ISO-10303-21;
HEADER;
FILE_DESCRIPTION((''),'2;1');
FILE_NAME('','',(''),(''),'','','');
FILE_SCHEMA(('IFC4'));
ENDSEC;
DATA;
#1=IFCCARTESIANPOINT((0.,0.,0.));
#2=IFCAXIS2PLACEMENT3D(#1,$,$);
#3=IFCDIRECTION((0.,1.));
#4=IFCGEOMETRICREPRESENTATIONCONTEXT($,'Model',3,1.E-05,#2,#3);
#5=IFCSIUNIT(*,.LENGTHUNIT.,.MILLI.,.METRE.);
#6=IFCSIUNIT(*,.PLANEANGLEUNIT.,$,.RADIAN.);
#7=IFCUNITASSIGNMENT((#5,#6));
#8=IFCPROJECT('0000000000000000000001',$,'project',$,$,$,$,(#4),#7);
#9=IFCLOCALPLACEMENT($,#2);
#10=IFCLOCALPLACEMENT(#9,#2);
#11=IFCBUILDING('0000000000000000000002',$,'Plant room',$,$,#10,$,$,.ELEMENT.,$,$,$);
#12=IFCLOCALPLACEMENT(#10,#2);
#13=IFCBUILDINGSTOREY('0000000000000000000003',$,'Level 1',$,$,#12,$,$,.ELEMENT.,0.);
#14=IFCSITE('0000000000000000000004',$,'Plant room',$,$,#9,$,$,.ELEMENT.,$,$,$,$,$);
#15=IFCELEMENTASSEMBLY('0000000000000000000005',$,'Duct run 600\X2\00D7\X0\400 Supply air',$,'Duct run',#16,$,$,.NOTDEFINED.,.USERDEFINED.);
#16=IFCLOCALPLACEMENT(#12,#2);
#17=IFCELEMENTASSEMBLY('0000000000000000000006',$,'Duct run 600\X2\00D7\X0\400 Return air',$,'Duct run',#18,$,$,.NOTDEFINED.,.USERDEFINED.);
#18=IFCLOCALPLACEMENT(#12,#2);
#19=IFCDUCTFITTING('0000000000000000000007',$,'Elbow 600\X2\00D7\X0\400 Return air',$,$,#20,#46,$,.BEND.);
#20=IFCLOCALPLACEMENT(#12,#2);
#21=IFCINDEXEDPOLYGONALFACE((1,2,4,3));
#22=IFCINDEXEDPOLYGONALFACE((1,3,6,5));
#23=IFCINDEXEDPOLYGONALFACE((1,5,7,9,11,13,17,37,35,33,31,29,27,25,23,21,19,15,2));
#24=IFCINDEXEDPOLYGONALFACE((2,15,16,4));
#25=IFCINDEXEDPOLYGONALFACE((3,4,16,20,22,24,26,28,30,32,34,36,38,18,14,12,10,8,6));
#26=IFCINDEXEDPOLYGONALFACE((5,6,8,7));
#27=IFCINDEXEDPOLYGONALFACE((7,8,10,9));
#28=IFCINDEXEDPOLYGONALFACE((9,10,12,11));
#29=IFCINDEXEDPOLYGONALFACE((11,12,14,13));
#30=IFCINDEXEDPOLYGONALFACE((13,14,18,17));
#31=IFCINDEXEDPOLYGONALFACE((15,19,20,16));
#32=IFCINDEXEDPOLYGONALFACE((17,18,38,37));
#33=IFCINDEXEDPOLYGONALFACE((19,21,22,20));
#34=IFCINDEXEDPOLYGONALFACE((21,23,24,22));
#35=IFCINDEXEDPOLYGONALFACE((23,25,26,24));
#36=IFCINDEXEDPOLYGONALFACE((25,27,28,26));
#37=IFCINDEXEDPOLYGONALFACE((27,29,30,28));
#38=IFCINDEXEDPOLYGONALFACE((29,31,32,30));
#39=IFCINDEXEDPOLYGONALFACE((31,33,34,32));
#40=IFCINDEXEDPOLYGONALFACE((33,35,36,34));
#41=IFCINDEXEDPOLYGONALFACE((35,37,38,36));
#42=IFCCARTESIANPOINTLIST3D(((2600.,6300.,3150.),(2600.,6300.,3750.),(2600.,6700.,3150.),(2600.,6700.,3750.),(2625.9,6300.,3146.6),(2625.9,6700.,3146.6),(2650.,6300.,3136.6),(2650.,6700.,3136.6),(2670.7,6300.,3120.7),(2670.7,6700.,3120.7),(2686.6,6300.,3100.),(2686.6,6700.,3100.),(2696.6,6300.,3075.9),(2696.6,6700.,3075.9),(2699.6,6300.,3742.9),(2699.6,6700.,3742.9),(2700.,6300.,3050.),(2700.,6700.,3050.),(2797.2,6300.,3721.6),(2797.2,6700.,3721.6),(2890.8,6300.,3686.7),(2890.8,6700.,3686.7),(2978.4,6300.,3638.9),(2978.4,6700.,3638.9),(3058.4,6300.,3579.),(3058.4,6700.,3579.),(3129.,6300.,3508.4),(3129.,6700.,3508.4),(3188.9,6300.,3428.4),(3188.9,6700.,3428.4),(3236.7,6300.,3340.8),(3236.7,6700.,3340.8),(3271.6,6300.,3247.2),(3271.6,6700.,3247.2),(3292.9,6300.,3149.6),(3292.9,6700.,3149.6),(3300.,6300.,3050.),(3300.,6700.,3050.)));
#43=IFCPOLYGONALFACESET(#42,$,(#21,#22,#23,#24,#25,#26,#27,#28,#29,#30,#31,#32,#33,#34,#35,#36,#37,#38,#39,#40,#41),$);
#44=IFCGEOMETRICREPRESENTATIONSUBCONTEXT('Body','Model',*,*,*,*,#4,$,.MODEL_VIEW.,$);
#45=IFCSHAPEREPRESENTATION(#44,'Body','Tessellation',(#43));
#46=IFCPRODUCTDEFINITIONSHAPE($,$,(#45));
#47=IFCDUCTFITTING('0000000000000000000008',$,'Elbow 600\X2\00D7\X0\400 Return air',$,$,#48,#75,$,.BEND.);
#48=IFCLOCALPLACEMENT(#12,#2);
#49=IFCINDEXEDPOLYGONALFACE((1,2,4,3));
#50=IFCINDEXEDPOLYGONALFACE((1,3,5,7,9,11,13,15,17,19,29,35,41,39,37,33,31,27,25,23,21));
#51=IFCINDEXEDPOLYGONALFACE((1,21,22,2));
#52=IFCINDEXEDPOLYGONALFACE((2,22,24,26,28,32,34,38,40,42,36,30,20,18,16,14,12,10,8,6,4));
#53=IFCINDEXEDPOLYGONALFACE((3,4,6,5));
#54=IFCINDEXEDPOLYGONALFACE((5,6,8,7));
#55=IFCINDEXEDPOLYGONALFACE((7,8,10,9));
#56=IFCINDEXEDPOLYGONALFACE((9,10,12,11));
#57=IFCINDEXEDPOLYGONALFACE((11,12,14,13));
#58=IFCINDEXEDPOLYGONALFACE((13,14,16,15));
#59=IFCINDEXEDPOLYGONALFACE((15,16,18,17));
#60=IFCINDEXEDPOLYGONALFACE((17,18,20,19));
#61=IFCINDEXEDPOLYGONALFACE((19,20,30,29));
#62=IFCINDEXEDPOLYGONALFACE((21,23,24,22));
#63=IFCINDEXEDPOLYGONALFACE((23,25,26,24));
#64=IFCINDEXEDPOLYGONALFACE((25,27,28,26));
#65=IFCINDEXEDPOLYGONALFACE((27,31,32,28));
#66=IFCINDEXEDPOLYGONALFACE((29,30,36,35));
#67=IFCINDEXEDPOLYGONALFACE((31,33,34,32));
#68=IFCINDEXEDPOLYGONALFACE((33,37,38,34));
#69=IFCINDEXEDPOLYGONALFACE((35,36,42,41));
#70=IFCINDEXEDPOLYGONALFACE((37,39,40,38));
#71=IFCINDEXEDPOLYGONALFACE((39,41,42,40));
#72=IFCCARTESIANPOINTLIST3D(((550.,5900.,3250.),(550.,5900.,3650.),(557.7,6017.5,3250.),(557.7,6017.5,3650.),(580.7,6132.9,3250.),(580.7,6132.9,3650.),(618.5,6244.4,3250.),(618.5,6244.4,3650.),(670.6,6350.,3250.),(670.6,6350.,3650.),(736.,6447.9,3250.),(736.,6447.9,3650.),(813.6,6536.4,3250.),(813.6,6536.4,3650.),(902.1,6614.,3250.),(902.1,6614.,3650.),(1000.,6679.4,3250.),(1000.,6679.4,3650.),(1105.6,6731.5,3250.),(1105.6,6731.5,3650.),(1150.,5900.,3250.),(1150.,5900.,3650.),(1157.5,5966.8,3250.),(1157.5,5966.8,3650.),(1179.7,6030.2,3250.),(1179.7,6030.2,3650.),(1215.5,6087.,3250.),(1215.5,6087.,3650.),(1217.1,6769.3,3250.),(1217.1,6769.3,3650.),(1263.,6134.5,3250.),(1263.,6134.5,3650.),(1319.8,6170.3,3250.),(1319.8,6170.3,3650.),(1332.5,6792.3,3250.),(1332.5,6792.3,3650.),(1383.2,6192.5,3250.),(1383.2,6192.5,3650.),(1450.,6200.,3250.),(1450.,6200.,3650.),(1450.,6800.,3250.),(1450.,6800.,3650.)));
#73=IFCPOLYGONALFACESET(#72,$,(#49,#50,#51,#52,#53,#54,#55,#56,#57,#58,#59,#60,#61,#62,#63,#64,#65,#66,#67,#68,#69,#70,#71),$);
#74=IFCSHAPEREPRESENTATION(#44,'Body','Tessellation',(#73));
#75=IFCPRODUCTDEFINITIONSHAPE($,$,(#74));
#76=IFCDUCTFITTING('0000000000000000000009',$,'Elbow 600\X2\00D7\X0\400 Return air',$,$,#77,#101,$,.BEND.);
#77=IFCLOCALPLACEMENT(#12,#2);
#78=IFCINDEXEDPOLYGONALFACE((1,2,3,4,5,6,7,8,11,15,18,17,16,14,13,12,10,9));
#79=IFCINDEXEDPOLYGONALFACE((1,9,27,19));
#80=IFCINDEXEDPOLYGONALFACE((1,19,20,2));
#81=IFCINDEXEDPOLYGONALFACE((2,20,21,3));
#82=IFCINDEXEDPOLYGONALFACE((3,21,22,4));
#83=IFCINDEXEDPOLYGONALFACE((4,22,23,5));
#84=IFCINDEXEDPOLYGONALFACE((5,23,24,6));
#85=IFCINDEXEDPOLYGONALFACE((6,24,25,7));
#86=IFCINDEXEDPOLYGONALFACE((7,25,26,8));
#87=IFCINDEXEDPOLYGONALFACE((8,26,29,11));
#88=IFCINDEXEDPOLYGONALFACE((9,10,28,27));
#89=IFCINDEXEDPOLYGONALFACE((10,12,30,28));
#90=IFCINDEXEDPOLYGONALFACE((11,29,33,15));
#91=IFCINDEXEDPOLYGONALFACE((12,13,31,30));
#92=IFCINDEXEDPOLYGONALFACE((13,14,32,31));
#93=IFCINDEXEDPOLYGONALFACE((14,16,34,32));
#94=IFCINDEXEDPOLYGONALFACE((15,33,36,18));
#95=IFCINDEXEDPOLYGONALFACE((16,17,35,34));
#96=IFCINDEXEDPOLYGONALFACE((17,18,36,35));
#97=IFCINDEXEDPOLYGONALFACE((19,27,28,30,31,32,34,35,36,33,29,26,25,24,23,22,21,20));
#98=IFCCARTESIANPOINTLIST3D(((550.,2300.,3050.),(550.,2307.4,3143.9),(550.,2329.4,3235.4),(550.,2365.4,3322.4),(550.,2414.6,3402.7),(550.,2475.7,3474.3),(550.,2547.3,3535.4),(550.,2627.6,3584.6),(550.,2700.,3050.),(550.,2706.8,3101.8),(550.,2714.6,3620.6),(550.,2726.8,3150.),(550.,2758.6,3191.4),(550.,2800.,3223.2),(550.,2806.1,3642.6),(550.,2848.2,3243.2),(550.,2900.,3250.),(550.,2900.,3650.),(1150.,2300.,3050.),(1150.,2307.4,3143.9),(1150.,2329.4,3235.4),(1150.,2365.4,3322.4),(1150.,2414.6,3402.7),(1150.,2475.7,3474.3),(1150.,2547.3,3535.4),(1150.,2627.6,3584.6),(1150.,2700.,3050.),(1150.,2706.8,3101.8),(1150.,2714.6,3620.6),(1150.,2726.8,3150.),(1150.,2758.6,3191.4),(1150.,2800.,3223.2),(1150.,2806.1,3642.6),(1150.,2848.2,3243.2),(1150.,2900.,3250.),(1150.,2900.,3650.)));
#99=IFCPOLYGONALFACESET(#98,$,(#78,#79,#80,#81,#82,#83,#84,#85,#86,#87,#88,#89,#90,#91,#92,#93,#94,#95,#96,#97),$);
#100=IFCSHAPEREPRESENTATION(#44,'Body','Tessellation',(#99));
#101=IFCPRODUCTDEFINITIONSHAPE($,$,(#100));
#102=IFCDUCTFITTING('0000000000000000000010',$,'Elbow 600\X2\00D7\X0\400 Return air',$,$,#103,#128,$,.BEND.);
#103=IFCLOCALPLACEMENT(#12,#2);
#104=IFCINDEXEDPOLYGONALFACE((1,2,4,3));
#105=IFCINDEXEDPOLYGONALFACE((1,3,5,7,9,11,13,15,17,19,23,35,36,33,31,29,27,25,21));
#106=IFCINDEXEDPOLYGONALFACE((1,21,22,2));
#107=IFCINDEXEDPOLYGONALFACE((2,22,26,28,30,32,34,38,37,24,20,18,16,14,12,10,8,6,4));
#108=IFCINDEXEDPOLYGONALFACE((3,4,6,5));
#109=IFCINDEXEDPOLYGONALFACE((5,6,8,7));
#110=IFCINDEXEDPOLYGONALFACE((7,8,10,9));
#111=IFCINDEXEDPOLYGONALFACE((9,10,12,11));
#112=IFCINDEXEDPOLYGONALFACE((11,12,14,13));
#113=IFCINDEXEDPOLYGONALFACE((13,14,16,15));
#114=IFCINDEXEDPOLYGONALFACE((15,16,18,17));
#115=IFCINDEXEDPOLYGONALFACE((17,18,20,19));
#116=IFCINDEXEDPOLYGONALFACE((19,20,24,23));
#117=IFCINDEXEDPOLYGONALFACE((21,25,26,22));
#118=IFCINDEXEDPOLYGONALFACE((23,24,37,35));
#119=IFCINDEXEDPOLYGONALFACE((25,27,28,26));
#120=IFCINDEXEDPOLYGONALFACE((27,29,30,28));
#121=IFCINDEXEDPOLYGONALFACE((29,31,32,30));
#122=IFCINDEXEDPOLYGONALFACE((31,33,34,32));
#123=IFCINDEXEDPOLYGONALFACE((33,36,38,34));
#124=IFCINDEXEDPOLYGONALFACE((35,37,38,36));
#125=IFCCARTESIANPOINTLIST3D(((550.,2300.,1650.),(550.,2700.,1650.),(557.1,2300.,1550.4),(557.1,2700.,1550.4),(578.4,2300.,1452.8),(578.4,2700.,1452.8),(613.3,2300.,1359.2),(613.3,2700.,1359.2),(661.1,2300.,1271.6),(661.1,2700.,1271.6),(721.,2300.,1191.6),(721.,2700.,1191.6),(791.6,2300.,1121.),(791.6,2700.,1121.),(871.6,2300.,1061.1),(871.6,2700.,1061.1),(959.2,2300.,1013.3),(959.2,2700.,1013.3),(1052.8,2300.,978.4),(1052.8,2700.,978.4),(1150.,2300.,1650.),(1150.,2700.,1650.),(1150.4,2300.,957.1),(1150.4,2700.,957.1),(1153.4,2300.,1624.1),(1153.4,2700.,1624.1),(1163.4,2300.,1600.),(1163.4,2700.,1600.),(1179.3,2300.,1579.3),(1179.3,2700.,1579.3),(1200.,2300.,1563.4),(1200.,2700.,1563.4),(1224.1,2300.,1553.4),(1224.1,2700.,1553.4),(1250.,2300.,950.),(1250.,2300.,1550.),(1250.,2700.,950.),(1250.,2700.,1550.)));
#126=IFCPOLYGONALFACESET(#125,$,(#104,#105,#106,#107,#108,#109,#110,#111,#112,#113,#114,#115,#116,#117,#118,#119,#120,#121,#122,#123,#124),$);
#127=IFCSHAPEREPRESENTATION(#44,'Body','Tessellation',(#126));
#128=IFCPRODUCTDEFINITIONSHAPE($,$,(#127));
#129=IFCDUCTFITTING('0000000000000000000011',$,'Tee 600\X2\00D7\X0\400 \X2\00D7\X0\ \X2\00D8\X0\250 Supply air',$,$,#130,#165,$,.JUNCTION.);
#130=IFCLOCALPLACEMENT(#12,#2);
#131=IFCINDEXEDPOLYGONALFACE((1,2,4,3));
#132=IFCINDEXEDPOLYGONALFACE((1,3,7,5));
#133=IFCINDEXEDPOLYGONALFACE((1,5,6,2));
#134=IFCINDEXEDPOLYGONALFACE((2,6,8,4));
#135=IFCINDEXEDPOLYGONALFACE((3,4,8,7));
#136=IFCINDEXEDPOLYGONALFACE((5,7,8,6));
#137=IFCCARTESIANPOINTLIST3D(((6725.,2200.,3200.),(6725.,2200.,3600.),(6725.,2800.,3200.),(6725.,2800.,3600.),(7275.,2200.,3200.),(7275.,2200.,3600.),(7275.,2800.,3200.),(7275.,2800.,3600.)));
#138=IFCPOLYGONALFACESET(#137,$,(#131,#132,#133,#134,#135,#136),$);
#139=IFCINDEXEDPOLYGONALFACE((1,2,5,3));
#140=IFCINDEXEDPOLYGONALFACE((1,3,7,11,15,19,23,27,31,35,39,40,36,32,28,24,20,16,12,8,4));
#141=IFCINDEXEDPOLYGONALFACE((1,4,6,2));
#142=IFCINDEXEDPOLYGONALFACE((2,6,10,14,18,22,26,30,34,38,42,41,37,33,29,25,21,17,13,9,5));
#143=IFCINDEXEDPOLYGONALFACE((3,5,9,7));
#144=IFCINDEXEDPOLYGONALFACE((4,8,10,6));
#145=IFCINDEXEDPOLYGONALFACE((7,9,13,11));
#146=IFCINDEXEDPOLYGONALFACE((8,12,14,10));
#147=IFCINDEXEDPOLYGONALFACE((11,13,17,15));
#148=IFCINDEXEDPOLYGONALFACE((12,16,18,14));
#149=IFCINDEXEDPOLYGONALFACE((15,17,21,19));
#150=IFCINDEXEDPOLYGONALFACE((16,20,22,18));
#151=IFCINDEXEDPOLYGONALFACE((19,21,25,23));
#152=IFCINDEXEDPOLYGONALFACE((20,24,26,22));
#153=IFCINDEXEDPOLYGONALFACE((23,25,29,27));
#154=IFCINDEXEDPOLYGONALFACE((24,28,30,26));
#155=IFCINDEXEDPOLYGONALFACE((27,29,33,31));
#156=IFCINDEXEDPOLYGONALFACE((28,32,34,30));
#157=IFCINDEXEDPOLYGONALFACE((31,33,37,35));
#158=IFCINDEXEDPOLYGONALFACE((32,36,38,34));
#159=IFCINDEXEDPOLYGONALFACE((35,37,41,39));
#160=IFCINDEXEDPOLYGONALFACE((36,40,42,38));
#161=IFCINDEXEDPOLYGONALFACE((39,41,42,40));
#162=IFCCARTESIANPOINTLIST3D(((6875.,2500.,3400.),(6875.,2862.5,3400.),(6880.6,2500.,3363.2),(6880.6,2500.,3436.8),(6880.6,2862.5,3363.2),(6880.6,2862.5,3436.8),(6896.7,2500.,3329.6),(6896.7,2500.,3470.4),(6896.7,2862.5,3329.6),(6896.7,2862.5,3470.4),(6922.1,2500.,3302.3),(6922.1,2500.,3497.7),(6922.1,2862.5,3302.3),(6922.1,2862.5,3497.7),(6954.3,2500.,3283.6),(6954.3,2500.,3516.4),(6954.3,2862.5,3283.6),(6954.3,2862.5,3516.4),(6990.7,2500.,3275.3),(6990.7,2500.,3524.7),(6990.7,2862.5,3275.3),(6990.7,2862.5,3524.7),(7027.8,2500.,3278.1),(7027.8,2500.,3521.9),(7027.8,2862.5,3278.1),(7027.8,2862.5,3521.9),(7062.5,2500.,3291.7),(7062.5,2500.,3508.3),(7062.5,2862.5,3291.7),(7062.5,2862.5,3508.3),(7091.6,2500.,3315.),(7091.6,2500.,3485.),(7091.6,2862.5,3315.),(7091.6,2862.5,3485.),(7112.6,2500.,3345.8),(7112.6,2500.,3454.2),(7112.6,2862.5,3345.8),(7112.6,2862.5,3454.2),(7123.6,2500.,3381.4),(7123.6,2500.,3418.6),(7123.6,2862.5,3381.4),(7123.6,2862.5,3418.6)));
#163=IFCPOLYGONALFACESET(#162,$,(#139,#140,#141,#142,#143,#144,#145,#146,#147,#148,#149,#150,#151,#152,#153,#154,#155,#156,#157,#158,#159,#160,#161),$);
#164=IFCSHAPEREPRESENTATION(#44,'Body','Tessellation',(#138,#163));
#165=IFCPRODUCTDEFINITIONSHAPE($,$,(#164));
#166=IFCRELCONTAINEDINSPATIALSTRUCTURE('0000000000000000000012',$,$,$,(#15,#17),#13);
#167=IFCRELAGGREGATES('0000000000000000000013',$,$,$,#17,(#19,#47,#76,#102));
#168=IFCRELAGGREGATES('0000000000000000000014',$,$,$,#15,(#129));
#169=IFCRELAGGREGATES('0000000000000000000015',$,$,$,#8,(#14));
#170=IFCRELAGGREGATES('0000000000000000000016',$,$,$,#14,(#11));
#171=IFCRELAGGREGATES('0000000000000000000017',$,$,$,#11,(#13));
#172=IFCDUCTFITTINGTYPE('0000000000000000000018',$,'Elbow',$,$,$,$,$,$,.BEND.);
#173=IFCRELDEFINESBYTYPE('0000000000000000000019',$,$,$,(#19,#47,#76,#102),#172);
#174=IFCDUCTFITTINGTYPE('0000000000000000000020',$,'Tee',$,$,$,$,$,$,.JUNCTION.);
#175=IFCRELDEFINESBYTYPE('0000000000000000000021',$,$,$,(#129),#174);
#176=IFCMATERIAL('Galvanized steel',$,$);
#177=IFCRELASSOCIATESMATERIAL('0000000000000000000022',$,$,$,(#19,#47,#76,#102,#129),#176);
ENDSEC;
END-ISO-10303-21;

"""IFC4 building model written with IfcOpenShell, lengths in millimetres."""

from ifc_helpers import new_model, entity, si_unit, direction, frame, origin, origin_with_axes, origin_2d, place, context, subcontext, project, spatial, rectangle, circle, extrude, material, type_object, element, aggregate, save


model = new_model("IFC4")

# Units and contexts
model_context = context("Model", 3, precision=1e-05, world=origin(), true_north=direction((0.0, 1.0)))
body_context = subcontext(model_context, "Body", "Model", "MODEL_VIEW")
ifc_project = project(units=[si_unit("LENGTHUNIT", "METRE", prefix="MILLI"), si_unit("PLANEANGLEUNIT", "RADIAN")], contexts=[model_context])

# Site, building, storey
site_placement = place(None, origin())
site = spatial("IfcSite", under=ifc_project, at=site_placement, Name="Plant room", CompositionType="ELEMENT")
building_placement = place(site_placement, origin())
building = spatial("IfcBuilding", under=site, at=building_placement, Name="Plant room", CompositionType="ELEMENT")
storey_placement = place(building_placement, origin())
storey = spatial("IfcBuildingStorey", under=building, at=storey_placement, Name="Level 1", CompositionType="ELEMENT", Elevation=0.0)

# Element assemblies
assembly_1_placement = place(storey_placement, origin_with_axes())
assembly_1 = element("IfcElementAssembly", 1, at=assembly_1_placement, inside=storey, Name="Duct run 600×400 Supply air", ObjectType="Duct run", AssemblyPlace="NOTDEFINED", PredefinedType="USERDEFINED")
ifc_material_1 = material(Name="Galvanized steel")
assembly_2_placement = place(storey_placement, origin_with_axes())
assembly_2 = element("IfcElementAssembly", 2, at=assembly_2_placement, inside=storey, Name="Duct run 600×400 Return air", ObjectType="Duct run", AssemblyPlace="NOTDEFINED", PredefinedType="USERDEFINED")

# Shared definitions
duct_fitting_type_1 = type_object("IfcDuctFittingType", Name="Elbow", PredefinedType="BEND")

# Duct fittings
duct_fitting_1_placement = place(storey_placement, origin_with_axes())
duct_fitting_1 = element("IfcDuctFitting", 3, at=duct_fitting_1_placement, type_object=duct_fitting_type_1, material=ifc_material_1, Name="Elbow 600×400 Return air", PredefinedType="BEND", context=body_context, shape_type="SweptSolid", body=[
    entity("IfcRevolvedAreaSolid", entity("IfcRectangleProfileDef", "AREA", None, entity("IfcAxis2Placement2D", entity("IfcCartesianPoint", [0.0, 0.0])), 600.0, 400.0), entity("IfcAxis2Placement3D", entity("IfcCartesianPoint", [3000.0, 6500.0, 3050.0]), entity("IfcDirection", [0.0, 0.0, 1.0]), entity("IfcDirection", [1.0, 0.0, 0.0])), entity("IfcAxis1Placement", entity("IfcCartesianPoint", [-400.0, 0.0, 0.0]), entity("IfcDirection", [0.0, -1.0, 0.0])), 1.570796),
])
duct_fitting_2_placement = place(storey_placement, origin_with_axes())
duct_fitting_2 = element("IfcDuctFitting", 4, at=duct_fitting_2_placement, type_object=duct_fitting_type_1, material=ifc_material_1, Name="Elbow 600×400 Return air", PredefinedType="BEND", context=body_context, shape_type="SweptSolid", body=[
    entity("IfcRevolvedAreaSolid", entity("IfcRectangleProfileDef", "AREA", None, entity("IfcAxis2Placement2D", entity("IfcCartesianPoint", [0.0, 0.0])), 600.0, 400.0), entity("IfcAxis2Placement3D", entity("IfcCartesianPoint", [1450.0, 6500.0, 3450.0]), entity("IfcDirection", [-1.0, 0.0, 0.0]), entity("IfcDirection", [0.0, -1.0, 0.0])), entity("IfcAxis1Placement", entity("IfcCartesianPoint", [600.0, 0.0, 0.0]), entity("IfcDirection", [0.0, 1.0, 0.0])), 1.570796),
])
duct_fitting_3_placement = place(storey_placement, origin_with_axes())
duct_fitting_3 = element("IfcDuctFitting", 5, at=duct_fitting_3_placement, type_object=duct_fitting_type_1, material=ifc_material_1, Name="Elbow 600×400 Return air", PredefinedType="BEND", context=body_context, shape_type="SweptSolid", body=[
    entity("IfcRevolvedAreaSolid", entity("IfcRectangleProfileDef", "AREA", None, entity("IfcAxis2Placement2D", entity("IfcCartesianPoint", [0.0, 0.0])), 600.0, 400.0), entity("IfcAxis2Placement3D", entity("IfcCartesianPoint", [850.0, 2900.0, 3450.0]), entity("IfcDirection", [0.0, -1.0, 0.0]), entity("IfcDirection", [1.0, 0.0, 0.0])), entity("IfcAxis1Placement", entity("IfcCartesianPoint", [0.0, -400.0, 0.0]), entity("IfcDirection", [1.0, 0.0, 0.0])), 1.570796),
])
duct_fitting_4_placement = place(storey_placement, origin_with_axes())
duct_fitting_4 = element("IfcDuctFitting", 6, at=duct_fitting_4_placement, type_object=duct_fitting_type_1, material=ifc_material_1, Name="Elbow 600×400 Return air", PredefinedType="BEND", context=body_context, shape_type="SweptSolid", body=[
    entity("IfcRevolvedAreaSolid", entity("IfcRectangleProfileDef", "AREA", None, entity("IfcAxis2Placement2D", entity("IfcCartesianPoint", [0.0, 0.0])), 600.0, 400.0), entity("IfcAxis2Placement3D", entity("IfcCartesianPoint", [850.0, 2500.0, 1650.0]), entity("IfcDirection", [0.0, 0.0, -1.0]), entity("IfcDirection", [1.0, 0.0, 0.0])), entity("IfcAxis1Placement", entity("IfcCartesianPoint", [400.0, 0.0, 0.0]), entity("IfcDirection", [0.0, 1.0, 0.0])), 1.570796),
])
aggregate(assembly_2, [duct_fitting_1, duct_fitting_2, duct_fitting_3, duct_fitting_4])
duct_fitting_type_2 = type_object("IfcDuctFittingType", Name="Tee", PredefinedType="JUNCTION")
duct_fitting_5_placement = place(storey_placement, origin_with_axes())
duct_fitting_5 = element("IfcDuctFitting", 7, at=duct_fitting_5_placement, type_object=duct_fitting_type_2, material=ifc_material_1, Name="Tee 600×400 × Ø250 Supply air", PredefinedType="JUNCTION", context=body_context, shape_type="SweptSolid", body=[
    extrude(rectangle(XDim=600.0, YDim=400.0, at=origin_2d()), frame((6725.0, 2500.0, 3400.0), z_axis=(1.0, 0.0, 0.0), x_axis=(0.0, 1.0, 0.0)), (0.0, 0.0, 1.0), 550.0),
    extrude(circle(Radius=125.0, at=origin_2d()), frame((7000.0, 2500.0, 3400.0), z_axis=(0.0, 1.0, 0.0), x_axis=(-1.0, 0.0, 0.0)), (0.0, 0.0, 1.0), 362.5),
])
aggregate(assembly_1, [duct_fitting_5])

save(model, "model.ifc")
